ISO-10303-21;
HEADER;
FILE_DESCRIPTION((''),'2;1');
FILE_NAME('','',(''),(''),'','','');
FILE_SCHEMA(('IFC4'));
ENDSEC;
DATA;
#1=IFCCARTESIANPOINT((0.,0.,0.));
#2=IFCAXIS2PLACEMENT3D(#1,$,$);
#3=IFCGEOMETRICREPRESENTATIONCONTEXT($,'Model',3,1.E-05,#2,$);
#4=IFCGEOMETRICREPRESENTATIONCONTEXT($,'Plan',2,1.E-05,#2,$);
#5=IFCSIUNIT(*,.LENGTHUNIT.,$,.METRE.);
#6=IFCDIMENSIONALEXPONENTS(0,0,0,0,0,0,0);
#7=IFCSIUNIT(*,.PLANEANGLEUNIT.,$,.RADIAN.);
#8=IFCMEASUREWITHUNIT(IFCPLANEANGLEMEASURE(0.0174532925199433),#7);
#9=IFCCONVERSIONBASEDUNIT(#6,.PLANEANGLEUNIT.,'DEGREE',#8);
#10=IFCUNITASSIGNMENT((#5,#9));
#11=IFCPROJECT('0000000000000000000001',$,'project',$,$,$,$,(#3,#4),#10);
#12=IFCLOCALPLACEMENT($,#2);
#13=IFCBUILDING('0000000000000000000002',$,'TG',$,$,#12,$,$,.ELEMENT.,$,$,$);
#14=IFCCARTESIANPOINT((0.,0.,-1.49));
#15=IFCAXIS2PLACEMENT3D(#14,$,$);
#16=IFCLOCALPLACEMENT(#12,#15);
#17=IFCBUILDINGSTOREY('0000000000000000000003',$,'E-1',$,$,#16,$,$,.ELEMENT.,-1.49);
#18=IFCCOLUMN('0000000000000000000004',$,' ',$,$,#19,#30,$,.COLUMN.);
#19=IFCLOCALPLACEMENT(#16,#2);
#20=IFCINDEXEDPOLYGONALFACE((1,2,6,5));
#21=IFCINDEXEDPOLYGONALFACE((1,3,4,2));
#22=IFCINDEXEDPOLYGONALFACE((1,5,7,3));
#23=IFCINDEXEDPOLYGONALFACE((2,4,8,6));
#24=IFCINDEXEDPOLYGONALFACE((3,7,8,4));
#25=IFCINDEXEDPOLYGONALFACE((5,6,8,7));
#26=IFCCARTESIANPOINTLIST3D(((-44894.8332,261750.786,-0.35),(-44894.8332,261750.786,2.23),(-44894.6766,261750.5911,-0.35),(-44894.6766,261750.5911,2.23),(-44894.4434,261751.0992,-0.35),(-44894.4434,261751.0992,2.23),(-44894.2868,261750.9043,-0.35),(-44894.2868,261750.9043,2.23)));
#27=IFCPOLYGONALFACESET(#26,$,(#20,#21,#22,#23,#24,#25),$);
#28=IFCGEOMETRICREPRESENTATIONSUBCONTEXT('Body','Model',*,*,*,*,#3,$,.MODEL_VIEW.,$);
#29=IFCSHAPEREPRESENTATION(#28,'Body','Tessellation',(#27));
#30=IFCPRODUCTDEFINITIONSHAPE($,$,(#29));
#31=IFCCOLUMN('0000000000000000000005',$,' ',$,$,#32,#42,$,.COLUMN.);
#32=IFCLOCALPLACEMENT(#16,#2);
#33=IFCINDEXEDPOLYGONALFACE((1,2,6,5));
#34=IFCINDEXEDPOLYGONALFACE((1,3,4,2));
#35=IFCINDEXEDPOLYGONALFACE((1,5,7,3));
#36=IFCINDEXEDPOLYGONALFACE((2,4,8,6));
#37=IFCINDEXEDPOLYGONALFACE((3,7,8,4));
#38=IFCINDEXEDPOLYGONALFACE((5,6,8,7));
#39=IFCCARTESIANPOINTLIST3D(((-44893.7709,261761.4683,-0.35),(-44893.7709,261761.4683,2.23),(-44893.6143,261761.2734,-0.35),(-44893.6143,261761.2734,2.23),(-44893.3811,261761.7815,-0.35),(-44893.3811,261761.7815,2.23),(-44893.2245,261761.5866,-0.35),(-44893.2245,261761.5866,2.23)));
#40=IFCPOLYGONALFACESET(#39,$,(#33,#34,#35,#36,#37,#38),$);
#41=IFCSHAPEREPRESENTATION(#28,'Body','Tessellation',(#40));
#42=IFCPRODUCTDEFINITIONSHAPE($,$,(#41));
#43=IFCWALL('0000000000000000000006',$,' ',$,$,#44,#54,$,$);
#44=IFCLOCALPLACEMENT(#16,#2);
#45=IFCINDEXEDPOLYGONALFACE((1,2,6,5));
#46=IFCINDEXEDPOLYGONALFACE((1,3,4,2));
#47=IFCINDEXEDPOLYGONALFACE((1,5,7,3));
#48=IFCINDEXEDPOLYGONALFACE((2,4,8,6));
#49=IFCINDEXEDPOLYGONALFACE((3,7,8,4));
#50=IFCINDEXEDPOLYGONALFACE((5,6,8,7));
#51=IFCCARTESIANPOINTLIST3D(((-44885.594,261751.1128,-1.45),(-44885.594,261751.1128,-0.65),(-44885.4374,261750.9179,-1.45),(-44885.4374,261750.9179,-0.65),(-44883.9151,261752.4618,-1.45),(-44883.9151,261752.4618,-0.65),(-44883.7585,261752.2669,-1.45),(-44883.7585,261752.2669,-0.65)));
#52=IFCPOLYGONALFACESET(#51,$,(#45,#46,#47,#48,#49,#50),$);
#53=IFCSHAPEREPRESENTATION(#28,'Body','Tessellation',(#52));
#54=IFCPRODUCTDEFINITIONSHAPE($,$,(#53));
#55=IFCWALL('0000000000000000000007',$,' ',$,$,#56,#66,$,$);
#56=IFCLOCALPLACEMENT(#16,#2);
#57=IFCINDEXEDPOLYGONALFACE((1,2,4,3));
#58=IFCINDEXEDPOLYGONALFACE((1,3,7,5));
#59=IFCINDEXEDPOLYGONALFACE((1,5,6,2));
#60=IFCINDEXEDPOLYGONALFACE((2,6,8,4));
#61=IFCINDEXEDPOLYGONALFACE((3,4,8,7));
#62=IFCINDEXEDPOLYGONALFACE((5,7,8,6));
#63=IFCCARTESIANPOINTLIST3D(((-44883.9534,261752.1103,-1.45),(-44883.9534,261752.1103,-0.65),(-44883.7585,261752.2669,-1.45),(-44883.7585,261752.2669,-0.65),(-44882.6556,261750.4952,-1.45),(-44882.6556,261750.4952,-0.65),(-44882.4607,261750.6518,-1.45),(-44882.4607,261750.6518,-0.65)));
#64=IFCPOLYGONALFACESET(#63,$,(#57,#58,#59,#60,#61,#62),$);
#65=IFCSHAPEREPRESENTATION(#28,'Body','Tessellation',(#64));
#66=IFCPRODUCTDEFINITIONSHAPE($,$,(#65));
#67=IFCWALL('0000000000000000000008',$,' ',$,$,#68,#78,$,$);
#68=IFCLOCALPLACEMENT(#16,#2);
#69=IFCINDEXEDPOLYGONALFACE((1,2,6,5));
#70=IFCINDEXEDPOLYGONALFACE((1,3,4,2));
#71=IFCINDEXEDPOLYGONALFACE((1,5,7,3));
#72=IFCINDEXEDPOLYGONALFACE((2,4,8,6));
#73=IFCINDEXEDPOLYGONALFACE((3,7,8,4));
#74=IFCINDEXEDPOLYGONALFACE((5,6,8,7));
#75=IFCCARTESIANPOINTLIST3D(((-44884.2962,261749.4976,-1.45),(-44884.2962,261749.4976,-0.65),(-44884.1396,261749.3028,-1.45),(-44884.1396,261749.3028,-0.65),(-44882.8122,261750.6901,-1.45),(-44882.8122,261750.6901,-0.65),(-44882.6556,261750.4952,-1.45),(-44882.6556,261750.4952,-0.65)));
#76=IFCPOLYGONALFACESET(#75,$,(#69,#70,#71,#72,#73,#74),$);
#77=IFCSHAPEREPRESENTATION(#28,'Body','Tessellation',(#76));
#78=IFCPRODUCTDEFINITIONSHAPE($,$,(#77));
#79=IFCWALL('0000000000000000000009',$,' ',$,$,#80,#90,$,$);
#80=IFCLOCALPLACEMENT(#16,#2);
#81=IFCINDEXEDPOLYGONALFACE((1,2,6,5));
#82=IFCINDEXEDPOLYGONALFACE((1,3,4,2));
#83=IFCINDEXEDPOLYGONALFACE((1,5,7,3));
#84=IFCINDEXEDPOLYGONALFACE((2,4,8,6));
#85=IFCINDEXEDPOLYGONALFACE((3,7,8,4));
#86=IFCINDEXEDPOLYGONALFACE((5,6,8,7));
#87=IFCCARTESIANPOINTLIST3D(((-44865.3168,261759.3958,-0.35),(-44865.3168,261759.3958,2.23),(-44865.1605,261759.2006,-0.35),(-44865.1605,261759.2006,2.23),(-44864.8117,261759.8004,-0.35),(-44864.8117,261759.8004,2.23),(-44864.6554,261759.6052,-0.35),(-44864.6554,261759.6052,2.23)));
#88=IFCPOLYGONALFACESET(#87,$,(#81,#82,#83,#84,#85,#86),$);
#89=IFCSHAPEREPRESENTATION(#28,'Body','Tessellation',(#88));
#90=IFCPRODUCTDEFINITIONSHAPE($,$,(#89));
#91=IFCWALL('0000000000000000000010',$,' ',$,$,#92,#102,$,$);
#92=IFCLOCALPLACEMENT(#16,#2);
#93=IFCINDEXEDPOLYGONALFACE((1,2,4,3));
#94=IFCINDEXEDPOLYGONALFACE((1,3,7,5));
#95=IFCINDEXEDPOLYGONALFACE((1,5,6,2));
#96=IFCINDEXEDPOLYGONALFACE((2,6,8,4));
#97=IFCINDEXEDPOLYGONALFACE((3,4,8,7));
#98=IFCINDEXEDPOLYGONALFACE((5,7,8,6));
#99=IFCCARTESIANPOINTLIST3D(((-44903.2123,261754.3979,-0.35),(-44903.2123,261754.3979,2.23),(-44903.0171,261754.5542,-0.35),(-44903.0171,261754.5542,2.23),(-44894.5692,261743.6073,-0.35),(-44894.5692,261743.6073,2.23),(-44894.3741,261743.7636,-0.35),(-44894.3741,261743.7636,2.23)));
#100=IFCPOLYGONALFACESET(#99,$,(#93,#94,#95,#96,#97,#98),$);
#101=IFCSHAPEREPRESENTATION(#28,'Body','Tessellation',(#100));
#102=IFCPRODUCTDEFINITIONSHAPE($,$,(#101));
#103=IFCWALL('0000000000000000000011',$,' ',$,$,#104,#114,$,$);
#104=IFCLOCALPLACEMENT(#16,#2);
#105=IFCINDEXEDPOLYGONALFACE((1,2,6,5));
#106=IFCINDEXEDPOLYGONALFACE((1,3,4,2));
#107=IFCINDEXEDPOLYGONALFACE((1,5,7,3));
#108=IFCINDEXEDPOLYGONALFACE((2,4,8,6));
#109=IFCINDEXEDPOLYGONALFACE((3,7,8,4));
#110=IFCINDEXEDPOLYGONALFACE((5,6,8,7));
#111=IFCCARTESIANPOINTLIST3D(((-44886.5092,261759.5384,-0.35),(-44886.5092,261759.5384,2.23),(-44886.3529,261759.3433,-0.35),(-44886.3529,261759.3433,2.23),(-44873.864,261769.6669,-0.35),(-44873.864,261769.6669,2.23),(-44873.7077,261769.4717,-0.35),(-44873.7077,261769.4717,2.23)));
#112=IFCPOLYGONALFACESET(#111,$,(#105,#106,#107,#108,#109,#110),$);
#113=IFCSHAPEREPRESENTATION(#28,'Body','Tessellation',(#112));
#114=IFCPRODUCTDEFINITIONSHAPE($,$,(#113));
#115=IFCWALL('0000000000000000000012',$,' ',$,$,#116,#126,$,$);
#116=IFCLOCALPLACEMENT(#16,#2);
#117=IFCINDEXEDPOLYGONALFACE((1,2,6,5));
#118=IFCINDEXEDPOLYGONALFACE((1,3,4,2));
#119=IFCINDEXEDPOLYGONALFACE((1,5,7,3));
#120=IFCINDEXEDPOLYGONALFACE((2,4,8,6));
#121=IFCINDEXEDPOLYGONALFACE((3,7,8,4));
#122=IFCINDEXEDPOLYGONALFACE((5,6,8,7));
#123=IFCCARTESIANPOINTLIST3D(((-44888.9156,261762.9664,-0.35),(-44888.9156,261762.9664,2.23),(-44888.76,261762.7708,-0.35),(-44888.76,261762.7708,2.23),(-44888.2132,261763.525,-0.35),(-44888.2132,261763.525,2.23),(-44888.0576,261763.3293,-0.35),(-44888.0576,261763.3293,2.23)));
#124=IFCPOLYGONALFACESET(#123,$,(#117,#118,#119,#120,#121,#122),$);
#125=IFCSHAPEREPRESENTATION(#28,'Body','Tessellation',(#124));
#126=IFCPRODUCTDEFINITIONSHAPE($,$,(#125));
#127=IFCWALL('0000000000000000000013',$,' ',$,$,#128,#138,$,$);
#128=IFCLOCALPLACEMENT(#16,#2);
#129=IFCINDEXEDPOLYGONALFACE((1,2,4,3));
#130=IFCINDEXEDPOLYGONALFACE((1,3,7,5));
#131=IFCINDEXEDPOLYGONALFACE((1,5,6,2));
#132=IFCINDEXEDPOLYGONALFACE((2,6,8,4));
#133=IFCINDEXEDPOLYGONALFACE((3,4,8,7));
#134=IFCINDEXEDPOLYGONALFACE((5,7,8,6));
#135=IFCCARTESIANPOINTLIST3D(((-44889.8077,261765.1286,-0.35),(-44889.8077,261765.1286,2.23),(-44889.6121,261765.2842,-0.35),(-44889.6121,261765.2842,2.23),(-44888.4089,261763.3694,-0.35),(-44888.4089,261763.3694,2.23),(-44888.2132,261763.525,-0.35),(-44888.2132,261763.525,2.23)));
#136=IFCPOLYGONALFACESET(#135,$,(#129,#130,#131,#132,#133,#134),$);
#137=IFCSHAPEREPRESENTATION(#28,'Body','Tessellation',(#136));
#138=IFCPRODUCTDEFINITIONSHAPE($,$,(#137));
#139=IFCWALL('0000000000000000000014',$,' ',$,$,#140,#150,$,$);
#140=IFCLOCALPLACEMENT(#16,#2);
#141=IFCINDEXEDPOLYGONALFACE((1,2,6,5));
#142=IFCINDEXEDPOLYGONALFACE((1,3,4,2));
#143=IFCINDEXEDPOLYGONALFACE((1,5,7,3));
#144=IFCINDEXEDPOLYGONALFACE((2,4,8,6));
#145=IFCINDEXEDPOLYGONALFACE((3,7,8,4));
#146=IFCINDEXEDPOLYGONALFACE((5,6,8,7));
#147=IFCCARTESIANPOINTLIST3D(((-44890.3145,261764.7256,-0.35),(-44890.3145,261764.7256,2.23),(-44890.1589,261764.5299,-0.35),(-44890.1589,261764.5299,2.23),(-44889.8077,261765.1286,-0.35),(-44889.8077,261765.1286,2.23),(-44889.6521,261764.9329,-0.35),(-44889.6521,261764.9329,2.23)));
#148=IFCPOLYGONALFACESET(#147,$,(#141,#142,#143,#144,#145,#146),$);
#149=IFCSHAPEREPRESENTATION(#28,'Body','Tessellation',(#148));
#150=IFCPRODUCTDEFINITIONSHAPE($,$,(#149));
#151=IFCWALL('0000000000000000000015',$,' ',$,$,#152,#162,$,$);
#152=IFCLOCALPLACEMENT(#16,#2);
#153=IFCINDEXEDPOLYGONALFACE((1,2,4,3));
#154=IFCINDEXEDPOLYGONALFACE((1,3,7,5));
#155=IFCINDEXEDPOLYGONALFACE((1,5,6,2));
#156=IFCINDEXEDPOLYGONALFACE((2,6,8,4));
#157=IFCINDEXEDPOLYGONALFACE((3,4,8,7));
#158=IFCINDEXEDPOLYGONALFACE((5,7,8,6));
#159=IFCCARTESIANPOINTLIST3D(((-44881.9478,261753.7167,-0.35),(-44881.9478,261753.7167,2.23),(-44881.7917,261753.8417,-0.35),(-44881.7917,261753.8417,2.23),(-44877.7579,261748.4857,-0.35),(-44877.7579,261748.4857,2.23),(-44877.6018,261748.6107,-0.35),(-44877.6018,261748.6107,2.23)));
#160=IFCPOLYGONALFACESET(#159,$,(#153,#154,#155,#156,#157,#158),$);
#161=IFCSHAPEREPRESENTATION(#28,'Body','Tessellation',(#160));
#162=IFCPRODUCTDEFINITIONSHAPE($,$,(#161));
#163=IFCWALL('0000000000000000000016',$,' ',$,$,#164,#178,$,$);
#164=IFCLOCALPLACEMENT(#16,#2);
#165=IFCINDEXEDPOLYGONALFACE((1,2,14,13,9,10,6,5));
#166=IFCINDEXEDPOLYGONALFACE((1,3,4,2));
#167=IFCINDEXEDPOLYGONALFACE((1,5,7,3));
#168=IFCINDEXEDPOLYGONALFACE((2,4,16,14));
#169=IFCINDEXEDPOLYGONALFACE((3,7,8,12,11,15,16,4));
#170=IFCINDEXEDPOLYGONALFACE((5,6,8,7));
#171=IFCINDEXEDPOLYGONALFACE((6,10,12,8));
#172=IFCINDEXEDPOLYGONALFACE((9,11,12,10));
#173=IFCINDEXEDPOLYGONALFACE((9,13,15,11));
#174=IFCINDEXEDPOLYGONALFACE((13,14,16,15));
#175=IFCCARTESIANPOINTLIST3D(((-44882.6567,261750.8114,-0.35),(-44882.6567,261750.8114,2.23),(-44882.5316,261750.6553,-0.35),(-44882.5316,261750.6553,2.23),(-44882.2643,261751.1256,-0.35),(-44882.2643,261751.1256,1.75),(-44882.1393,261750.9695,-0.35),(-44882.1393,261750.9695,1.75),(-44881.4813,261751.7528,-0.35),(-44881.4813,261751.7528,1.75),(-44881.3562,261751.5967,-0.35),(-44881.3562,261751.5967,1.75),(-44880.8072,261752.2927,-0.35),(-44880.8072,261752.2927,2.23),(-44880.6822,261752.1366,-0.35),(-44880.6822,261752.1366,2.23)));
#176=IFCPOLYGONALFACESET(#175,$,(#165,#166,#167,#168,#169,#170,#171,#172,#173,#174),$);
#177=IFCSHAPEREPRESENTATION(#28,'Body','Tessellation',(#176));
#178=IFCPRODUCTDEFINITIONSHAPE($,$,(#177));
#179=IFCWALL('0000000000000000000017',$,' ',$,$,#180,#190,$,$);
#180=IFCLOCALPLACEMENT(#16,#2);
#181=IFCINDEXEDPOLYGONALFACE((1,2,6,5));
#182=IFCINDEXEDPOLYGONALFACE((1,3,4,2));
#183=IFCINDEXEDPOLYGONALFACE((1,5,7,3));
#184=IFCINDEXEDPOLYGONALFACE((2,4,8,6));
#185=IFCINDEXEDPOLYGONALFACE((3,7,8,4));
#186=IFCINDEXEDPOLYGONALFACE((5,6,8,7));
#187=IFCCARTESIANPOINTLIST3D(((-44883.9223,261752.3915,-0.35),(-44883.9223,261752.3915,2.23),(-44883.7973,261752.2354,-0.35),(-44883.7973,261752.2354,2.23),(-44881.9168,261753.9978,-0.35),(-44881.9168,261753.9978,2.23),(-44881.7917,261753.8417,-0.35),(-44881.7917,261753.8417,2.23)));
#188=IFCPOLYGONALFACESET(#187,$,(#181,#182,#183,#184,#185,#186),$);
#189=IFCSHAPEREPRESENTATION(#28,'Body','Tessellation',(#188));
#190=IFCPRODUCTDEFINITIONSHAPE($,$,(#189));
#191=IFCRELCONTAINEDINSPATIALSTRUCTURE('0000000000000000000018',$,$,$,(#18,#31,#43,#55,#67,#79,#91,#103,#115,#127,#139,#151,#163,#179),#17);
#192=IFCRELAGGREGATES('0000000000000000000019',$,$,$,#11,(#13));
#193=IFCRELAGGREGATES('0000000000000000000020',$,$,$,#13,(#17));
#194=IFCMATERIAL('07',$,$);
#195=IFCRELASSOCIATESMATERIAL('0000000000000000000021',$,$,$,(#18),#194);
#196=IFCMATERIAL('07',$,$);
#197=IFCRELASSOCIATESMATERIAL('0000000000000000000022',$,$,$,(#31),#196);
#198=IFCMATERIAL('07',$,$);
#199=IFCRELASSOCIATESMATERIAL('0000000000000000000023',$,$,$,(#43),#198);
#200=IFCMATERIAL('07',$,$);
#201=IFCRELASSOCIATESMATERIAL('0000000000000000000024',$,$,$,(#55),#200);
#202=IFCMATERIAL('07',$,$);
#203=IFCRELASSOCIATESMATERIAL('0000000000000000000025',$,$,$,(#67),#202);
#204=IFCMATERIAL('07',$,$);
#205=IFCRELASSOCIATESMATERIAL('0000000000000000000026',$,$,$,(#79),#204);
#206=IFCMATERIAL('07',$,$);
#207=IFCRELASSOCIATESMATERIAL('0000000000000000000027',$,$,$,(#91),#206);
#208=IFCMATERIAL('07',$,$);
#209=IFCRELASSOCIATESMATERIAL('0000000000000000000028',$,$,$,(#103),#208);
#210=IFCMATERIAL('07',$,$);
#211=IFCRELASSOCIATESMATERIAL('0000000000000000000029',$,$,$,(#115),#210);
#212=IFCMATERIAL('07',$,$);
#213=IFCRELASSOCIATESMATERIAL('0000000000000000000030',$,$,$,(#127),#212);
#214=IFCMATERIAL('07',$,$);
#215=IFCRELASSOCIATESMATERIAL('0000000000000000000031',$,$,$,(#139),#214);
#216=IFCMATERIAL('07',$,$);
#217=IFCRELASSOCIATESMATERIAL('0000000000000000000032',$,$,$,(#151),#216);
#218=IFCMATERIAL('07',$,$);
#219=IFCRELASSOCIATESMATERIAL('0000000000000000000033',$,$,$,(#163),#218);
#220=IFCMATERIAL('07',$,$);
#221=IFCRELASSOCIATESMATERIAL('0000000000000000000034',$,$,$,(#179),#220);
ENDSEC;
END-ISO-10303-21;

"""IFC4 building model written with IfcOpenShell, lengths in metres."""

from ifc_helpers import new_model, entity, si_unit, converted_unit, frame, frame_2d, origin, origin_with_axes, place, context, subcontext, project, spatial, polyline, rectangle, outline, extrude, material, element, save


model = new_model("IFC4")

# Units and contexts
model_context = context("Model", 3, precision=1e-05, world=origin())
plan_context = context("Plan", 2, precision=1e-05, world=origin())
body_context = subcontext(model_context, "Body", "Model", "MODEL_VIEW")
ifc_project = project(units=[si_unit("LENGTHUNIT", "METRE"), converted_unit("PLANEANGLEUNIT", "DEGREE", entity("IfcPlaneAngleMeasure", 0.0174532925199433), si_unit("PLANEANGLEUNIT", "RADIAN"), dimensions=[0, 0, 0, 0, 0, 0, 0])], contexts=[model_context, plan_context])

# Building, storey
building_placement = place(None, origin())
building = spatial("IfcBuilding", under=ifc_project, at=building_placement, Name="TG", CompositionType="ELEMENT")
storey_placement = place(building_placement, frame((0.0, 0.0, -1.49)))
storey = spatial("IfcBuildingStorey", under=building, at=storey_placement, Name="E-1", CompositionType="ELEMENT", Elevation=-1.49)

# Columns
ifc_material_1 = material(Name="07")
column_1_placement = place(storey_placement, frame((-44894.4434, 261751.0992, -0.35)))
element("IfcColumn", 1, at=column_1_placement, inside=storey, material=ifc_material_1, Name=" ", PredefinedType="COLUMN", context=body_context, shape_type="SweptSolid", body=[
    extrude(rectangle(XDim=0.5, YDim=0.25, at=frame_2d((-0.1166, -0.254), x_axis=(-0.779531, -0.626364))), origin_with_axes(), (0.0, 0.0, 1.0), 2.58),
])
ifc_material_2 = material(Name="07")
column_2_placement = place(storey_placement, frame((-44893.3811, 261761.7815, -0.35)))
element("IfcColumn", 2, at=column_2_placement, inside=storey, material=ifc_material_2, Name=" ", PredefinedType="COLUMN", context=body_context, shape_type="SweptSolid", body=[
    extrude(rectangle(XDim=0.5, YDim=0.25, at=frame_2d((-0.1166, -0.254), x_axis=(-0.779531, -0.626364))), origin_with_axes(), (0.0, 0.0, 1.0), 2.58),
])

# Walls
ifc_material_3 = material(Name="07")
wall_1_placement = place(storey_placement, frame((-44885.4374, 261750.9179, -1.45), z_axis=(0.0, 0.0, 1.0), x_axis=(0.779531, 0.626364, 0.0)))
element("IfcWall", 3, at=wall_1_placement, inside=storey, material=ifc_material_3, Name=" ", context=body_context, shape_type="SweptSolid", body=[
    extrude(rectangle(XDim=2.1538, YDim=0.25, at=frame_2d((1.0769, 0.125), x_axis=(1.0, 0.0))), origin_with_axes(), (0.0, 0.0, 1.0), 0.8),
])
ifc_material_4 = material(Name="07")
wall_2_placement = place(storey_placement, frame((-44883.9534, 261752.1103, -1.45), z_axis=(0.0, 0.0, 1.0), x_axis=(0.626364, -0.779531, 0.0)))
element("IfcWall", 4, at=wall_2_placement, inside=storey, material=ifc_material_4, Name=" ", context=body_context, shape_type="SweptSolid", body=[
    extrude(rectangle(XDim=2.0719, YDim=0.25, at=frame_2d((1.036, 0.125), x_axis=(1.0, 0.0))), origin_with_axes(), (0.0, 0.0, 1.0), 0.8),
])
ifc_material_5 = material(Name="07")
wall_3_placement = place(storey_placement, frame((-44882.8122, 261750.6901, -1.45), z_axis=(0.0, 0.0, 1.0), x_axis=(-0.779531, -0.626364, 0.0)))
element("IfcWall", 5, at=wall_3_placement, inside=storey, material=ifc_material_5, Name=" ", context=body_context, shape_type="SweptSolid", body=[
    extrude(rectangle(XDim=1.9038, YDim=0.25, at=frame_2d((0.9519, 0.125), x_axis=(1.0, 0.0))), origin_with_axes(), (0.0, 0.0, 1.0), 0.8),
])
ifc_material_6 = material(Name="07")
wall_4_placement = place(storey_placement, frame((-44864.8117, 261759.8004, -0.35), z_axis=(0.0, 0.0, 1.0), x_axis=(-0.780498, -0.625159, 0.0)))
element("IfcWall", 6, at=wall_4_placement, inside=storey, material=ifc_material_6, Name=" ", context=body_context, shape_type="SweptSolid", body=[
    extrude(rectangle(XDim=0.6472, YDim=0.25, at=frame_2d((0.3236, 0.125), x_axis=(1.0, 0.0))), origin_with_axes(), (0.0, 0.0, 1.0), 2.58),
])
ifc_material_7 = material(Name="07")
wall_5_placement = place(storey_placement, frame((-44903.2123, 261754.3979, -0.35), z_axis=(0.0, 0.0, 1.0), x_axis=(0.625159, -0.780498, 0.0)))
element("IfcWall", 7, at=wall_5_placement, inside=storey, material=ifc_material_7, Name=" ", context=body_context, shape_type="SweptSolid", body=[
    extrude(rectangle(XDim=13.8253, YDim=0.25, at=frame_2d((6.9127, 0.125), x_axis=(1.0, 0.0))), origin_with_axes(), (0.0, 0.0, 1.0), 2.58),
])
ifc_material_8 = material(Name="07")
wall_6_placement = place(storey_placement, frame((-44886.3529, 261759.3433, -0.35), z_axis=(0.0, 0.0, 1.0), x_axis=(0.780498, 0.625159, 0.0)))
element("IfcWall", 8, at=wall_6_placement, inside=storey, material=ifc_material_8, Name=" ", context=body_context, shape_type="SweptSolid", body=[
    extrude(rectangle(XDim=16.2014, YDim=0.25, at=frame_2d((8.1007, 0.125), x_axis=(1.0, 0.0))), origin_with_axes(), (0.0, 0.0, 1.0), 2.58),
])
ifc_material_9 = material(Name="07")
wall_7_placement = place(storey_placement, frame((-44888.76, 261762.7708, -0.35), z_axis=(0.0, 0.0, 1.0), x_axis=(0.782708, 0.622389, 0.0)))
element("IfcWall", 9, at=wall_7_placement, inside=storey, material=ifc_material_9, Name=" ", context=body_context, shape_type="SweptSolid", body=[
    extrude(rectangle(XDim=0.8974, YDim=0.25, at=frame_2d((0.4487, 0.125), x_axis=(1.0, 0.0))), origin_with_axes(), (0.0, 0.0, 1.0), 2.58),
])
ifc_material_10 = material(Name="07")
wall_8_placement = place(storey_placement, frame((-44888.2132, 261763.525, -0.35), z_axis=(0.0, 0.0, 1.0), x_axis=(-0.622389, 0.782708, 0.0)))
element("IfcWall", 10, at=wall_8_placement, inside=storey, material=ifc_material_10, Name=" ", context=body_context, shape_type="SweptSolid", body=[
    extrude(rectangle(XDim=2.2476, YDim=0.25, at=frame_2d((1.1238, 0.125), x_axis=(1.0, 0.0))), origin_with_axes(), (0.0, 0.0, 1.0), 2.58),
])
ifc_material_11 = material(Name="07")
wall_9_placement = place(storey_placement, frame((-44889.8077, 261765.1286, -0.35), z_axis=(0.0, 0.0, 1.0), x_axis=(-0.782708, -0.622389, 0.0)))
element("IfcWall", 11, at=wall_9_placement, inside=storey, material=ifc_material_11, Name=" ", context=body_context, shape_type="SweptSolid", body=[
    extrude(rectangle(XDim=0.6474, YDim=0.25, at=frame_2d((0.3237, 0.125), x_axis=(1.0, 0.0))), origin_with_axes(), (0.0, 0.0, 1.0), 2.58),
])

# Wall
ifc_material_12 = material(Name="07")
wall_10_placement = place(storey_placement, frame((-44881.9478, 261753.7167, -0.35), z_axis=(0.0, 0.0, 1.0), x_axis=(0.625159, -0.780498, 0.0)))
element("IfcWall", 12, at=wall_10_placement, inside=storey, material=ifc_material_12, Name=" ", context=body_context, shape_type="SweptSolid", body=[
    extrude(rectangle(XDim=6.7021, YDim=0.2, at=frame_2d((3.3511, 0.1), x_axis=(1.0, 0.0))), origin_with_axes(), (0.0, 0.0, 1.0), 2.58),
])

# Wall, opening
ifc_material_13 = material(Name="07")
wall_11_placement = place(storey_placement, frame((-44880.8072, 261752.2927, -0.35), z_axis=(0.0, 0.0, 1.0), x_axis=(-0.780498, -0.625159, 0.0)))
wall_11 = element("IfcWall", 13, at=wall_11_placement, inside=storey, material=ifc_material_13, Name=" ", context=body_context, shape_type="SweptSolid", body=[
    extrude(rectangle(XDim=2.3695, YDim=0.2, at=frame_2d((1.1848, 0.1), x_axis=(1.0, 0.0))), origin_with_axes(), (0.0, 0.0, 1.0), 2.58),
])
opening_1_placement = place(wall_11_placement, frame((1.8668, 0.2, 0.0), z_axis=(0.0, -1.0, 0.0), x_axis=(0.0, 0.0, 1.0)))
element("IfcOpeningElement", 14, at=opening_1_placement, cuts=wall_11, ObjectType="Opening", context=body_context, shape_type="SweptSolid", body=[
    extrude(outline(polyline([(0.0, 1.0033), (2.1, 1.0033), (2.1, 0.0), (0.0, 0.0), (0.0, 1.0033)])), origin_with_axes(), (0.0, 0.0, 1.0), 0.2),
])

# Wall
ifc_material_14 = material(Name="07")
wall_12_placement = place(storey_placement, frame((-44883.7973, 261752.2354, -0.35), z_axis=(0.0, 0.0, 1.0), x_axis=(0.780498, 0.625159, 0.0)))
element("IfcWall", 15, at=wall_12_placement, inside=storey, material=ifc_material_14, Name=" ", context=body_context, shape_type="SweptSolid", body=[
    extrude(rectangle(XDim=2.5695, YDim=0.2, at=frame_2d((1.2848, 0.1), x_axis=(1.0, 0.0))), origin_with_axes(), (0.0, 0.0, 1.0), 2.58),
])

save(model, "model.ifc")
